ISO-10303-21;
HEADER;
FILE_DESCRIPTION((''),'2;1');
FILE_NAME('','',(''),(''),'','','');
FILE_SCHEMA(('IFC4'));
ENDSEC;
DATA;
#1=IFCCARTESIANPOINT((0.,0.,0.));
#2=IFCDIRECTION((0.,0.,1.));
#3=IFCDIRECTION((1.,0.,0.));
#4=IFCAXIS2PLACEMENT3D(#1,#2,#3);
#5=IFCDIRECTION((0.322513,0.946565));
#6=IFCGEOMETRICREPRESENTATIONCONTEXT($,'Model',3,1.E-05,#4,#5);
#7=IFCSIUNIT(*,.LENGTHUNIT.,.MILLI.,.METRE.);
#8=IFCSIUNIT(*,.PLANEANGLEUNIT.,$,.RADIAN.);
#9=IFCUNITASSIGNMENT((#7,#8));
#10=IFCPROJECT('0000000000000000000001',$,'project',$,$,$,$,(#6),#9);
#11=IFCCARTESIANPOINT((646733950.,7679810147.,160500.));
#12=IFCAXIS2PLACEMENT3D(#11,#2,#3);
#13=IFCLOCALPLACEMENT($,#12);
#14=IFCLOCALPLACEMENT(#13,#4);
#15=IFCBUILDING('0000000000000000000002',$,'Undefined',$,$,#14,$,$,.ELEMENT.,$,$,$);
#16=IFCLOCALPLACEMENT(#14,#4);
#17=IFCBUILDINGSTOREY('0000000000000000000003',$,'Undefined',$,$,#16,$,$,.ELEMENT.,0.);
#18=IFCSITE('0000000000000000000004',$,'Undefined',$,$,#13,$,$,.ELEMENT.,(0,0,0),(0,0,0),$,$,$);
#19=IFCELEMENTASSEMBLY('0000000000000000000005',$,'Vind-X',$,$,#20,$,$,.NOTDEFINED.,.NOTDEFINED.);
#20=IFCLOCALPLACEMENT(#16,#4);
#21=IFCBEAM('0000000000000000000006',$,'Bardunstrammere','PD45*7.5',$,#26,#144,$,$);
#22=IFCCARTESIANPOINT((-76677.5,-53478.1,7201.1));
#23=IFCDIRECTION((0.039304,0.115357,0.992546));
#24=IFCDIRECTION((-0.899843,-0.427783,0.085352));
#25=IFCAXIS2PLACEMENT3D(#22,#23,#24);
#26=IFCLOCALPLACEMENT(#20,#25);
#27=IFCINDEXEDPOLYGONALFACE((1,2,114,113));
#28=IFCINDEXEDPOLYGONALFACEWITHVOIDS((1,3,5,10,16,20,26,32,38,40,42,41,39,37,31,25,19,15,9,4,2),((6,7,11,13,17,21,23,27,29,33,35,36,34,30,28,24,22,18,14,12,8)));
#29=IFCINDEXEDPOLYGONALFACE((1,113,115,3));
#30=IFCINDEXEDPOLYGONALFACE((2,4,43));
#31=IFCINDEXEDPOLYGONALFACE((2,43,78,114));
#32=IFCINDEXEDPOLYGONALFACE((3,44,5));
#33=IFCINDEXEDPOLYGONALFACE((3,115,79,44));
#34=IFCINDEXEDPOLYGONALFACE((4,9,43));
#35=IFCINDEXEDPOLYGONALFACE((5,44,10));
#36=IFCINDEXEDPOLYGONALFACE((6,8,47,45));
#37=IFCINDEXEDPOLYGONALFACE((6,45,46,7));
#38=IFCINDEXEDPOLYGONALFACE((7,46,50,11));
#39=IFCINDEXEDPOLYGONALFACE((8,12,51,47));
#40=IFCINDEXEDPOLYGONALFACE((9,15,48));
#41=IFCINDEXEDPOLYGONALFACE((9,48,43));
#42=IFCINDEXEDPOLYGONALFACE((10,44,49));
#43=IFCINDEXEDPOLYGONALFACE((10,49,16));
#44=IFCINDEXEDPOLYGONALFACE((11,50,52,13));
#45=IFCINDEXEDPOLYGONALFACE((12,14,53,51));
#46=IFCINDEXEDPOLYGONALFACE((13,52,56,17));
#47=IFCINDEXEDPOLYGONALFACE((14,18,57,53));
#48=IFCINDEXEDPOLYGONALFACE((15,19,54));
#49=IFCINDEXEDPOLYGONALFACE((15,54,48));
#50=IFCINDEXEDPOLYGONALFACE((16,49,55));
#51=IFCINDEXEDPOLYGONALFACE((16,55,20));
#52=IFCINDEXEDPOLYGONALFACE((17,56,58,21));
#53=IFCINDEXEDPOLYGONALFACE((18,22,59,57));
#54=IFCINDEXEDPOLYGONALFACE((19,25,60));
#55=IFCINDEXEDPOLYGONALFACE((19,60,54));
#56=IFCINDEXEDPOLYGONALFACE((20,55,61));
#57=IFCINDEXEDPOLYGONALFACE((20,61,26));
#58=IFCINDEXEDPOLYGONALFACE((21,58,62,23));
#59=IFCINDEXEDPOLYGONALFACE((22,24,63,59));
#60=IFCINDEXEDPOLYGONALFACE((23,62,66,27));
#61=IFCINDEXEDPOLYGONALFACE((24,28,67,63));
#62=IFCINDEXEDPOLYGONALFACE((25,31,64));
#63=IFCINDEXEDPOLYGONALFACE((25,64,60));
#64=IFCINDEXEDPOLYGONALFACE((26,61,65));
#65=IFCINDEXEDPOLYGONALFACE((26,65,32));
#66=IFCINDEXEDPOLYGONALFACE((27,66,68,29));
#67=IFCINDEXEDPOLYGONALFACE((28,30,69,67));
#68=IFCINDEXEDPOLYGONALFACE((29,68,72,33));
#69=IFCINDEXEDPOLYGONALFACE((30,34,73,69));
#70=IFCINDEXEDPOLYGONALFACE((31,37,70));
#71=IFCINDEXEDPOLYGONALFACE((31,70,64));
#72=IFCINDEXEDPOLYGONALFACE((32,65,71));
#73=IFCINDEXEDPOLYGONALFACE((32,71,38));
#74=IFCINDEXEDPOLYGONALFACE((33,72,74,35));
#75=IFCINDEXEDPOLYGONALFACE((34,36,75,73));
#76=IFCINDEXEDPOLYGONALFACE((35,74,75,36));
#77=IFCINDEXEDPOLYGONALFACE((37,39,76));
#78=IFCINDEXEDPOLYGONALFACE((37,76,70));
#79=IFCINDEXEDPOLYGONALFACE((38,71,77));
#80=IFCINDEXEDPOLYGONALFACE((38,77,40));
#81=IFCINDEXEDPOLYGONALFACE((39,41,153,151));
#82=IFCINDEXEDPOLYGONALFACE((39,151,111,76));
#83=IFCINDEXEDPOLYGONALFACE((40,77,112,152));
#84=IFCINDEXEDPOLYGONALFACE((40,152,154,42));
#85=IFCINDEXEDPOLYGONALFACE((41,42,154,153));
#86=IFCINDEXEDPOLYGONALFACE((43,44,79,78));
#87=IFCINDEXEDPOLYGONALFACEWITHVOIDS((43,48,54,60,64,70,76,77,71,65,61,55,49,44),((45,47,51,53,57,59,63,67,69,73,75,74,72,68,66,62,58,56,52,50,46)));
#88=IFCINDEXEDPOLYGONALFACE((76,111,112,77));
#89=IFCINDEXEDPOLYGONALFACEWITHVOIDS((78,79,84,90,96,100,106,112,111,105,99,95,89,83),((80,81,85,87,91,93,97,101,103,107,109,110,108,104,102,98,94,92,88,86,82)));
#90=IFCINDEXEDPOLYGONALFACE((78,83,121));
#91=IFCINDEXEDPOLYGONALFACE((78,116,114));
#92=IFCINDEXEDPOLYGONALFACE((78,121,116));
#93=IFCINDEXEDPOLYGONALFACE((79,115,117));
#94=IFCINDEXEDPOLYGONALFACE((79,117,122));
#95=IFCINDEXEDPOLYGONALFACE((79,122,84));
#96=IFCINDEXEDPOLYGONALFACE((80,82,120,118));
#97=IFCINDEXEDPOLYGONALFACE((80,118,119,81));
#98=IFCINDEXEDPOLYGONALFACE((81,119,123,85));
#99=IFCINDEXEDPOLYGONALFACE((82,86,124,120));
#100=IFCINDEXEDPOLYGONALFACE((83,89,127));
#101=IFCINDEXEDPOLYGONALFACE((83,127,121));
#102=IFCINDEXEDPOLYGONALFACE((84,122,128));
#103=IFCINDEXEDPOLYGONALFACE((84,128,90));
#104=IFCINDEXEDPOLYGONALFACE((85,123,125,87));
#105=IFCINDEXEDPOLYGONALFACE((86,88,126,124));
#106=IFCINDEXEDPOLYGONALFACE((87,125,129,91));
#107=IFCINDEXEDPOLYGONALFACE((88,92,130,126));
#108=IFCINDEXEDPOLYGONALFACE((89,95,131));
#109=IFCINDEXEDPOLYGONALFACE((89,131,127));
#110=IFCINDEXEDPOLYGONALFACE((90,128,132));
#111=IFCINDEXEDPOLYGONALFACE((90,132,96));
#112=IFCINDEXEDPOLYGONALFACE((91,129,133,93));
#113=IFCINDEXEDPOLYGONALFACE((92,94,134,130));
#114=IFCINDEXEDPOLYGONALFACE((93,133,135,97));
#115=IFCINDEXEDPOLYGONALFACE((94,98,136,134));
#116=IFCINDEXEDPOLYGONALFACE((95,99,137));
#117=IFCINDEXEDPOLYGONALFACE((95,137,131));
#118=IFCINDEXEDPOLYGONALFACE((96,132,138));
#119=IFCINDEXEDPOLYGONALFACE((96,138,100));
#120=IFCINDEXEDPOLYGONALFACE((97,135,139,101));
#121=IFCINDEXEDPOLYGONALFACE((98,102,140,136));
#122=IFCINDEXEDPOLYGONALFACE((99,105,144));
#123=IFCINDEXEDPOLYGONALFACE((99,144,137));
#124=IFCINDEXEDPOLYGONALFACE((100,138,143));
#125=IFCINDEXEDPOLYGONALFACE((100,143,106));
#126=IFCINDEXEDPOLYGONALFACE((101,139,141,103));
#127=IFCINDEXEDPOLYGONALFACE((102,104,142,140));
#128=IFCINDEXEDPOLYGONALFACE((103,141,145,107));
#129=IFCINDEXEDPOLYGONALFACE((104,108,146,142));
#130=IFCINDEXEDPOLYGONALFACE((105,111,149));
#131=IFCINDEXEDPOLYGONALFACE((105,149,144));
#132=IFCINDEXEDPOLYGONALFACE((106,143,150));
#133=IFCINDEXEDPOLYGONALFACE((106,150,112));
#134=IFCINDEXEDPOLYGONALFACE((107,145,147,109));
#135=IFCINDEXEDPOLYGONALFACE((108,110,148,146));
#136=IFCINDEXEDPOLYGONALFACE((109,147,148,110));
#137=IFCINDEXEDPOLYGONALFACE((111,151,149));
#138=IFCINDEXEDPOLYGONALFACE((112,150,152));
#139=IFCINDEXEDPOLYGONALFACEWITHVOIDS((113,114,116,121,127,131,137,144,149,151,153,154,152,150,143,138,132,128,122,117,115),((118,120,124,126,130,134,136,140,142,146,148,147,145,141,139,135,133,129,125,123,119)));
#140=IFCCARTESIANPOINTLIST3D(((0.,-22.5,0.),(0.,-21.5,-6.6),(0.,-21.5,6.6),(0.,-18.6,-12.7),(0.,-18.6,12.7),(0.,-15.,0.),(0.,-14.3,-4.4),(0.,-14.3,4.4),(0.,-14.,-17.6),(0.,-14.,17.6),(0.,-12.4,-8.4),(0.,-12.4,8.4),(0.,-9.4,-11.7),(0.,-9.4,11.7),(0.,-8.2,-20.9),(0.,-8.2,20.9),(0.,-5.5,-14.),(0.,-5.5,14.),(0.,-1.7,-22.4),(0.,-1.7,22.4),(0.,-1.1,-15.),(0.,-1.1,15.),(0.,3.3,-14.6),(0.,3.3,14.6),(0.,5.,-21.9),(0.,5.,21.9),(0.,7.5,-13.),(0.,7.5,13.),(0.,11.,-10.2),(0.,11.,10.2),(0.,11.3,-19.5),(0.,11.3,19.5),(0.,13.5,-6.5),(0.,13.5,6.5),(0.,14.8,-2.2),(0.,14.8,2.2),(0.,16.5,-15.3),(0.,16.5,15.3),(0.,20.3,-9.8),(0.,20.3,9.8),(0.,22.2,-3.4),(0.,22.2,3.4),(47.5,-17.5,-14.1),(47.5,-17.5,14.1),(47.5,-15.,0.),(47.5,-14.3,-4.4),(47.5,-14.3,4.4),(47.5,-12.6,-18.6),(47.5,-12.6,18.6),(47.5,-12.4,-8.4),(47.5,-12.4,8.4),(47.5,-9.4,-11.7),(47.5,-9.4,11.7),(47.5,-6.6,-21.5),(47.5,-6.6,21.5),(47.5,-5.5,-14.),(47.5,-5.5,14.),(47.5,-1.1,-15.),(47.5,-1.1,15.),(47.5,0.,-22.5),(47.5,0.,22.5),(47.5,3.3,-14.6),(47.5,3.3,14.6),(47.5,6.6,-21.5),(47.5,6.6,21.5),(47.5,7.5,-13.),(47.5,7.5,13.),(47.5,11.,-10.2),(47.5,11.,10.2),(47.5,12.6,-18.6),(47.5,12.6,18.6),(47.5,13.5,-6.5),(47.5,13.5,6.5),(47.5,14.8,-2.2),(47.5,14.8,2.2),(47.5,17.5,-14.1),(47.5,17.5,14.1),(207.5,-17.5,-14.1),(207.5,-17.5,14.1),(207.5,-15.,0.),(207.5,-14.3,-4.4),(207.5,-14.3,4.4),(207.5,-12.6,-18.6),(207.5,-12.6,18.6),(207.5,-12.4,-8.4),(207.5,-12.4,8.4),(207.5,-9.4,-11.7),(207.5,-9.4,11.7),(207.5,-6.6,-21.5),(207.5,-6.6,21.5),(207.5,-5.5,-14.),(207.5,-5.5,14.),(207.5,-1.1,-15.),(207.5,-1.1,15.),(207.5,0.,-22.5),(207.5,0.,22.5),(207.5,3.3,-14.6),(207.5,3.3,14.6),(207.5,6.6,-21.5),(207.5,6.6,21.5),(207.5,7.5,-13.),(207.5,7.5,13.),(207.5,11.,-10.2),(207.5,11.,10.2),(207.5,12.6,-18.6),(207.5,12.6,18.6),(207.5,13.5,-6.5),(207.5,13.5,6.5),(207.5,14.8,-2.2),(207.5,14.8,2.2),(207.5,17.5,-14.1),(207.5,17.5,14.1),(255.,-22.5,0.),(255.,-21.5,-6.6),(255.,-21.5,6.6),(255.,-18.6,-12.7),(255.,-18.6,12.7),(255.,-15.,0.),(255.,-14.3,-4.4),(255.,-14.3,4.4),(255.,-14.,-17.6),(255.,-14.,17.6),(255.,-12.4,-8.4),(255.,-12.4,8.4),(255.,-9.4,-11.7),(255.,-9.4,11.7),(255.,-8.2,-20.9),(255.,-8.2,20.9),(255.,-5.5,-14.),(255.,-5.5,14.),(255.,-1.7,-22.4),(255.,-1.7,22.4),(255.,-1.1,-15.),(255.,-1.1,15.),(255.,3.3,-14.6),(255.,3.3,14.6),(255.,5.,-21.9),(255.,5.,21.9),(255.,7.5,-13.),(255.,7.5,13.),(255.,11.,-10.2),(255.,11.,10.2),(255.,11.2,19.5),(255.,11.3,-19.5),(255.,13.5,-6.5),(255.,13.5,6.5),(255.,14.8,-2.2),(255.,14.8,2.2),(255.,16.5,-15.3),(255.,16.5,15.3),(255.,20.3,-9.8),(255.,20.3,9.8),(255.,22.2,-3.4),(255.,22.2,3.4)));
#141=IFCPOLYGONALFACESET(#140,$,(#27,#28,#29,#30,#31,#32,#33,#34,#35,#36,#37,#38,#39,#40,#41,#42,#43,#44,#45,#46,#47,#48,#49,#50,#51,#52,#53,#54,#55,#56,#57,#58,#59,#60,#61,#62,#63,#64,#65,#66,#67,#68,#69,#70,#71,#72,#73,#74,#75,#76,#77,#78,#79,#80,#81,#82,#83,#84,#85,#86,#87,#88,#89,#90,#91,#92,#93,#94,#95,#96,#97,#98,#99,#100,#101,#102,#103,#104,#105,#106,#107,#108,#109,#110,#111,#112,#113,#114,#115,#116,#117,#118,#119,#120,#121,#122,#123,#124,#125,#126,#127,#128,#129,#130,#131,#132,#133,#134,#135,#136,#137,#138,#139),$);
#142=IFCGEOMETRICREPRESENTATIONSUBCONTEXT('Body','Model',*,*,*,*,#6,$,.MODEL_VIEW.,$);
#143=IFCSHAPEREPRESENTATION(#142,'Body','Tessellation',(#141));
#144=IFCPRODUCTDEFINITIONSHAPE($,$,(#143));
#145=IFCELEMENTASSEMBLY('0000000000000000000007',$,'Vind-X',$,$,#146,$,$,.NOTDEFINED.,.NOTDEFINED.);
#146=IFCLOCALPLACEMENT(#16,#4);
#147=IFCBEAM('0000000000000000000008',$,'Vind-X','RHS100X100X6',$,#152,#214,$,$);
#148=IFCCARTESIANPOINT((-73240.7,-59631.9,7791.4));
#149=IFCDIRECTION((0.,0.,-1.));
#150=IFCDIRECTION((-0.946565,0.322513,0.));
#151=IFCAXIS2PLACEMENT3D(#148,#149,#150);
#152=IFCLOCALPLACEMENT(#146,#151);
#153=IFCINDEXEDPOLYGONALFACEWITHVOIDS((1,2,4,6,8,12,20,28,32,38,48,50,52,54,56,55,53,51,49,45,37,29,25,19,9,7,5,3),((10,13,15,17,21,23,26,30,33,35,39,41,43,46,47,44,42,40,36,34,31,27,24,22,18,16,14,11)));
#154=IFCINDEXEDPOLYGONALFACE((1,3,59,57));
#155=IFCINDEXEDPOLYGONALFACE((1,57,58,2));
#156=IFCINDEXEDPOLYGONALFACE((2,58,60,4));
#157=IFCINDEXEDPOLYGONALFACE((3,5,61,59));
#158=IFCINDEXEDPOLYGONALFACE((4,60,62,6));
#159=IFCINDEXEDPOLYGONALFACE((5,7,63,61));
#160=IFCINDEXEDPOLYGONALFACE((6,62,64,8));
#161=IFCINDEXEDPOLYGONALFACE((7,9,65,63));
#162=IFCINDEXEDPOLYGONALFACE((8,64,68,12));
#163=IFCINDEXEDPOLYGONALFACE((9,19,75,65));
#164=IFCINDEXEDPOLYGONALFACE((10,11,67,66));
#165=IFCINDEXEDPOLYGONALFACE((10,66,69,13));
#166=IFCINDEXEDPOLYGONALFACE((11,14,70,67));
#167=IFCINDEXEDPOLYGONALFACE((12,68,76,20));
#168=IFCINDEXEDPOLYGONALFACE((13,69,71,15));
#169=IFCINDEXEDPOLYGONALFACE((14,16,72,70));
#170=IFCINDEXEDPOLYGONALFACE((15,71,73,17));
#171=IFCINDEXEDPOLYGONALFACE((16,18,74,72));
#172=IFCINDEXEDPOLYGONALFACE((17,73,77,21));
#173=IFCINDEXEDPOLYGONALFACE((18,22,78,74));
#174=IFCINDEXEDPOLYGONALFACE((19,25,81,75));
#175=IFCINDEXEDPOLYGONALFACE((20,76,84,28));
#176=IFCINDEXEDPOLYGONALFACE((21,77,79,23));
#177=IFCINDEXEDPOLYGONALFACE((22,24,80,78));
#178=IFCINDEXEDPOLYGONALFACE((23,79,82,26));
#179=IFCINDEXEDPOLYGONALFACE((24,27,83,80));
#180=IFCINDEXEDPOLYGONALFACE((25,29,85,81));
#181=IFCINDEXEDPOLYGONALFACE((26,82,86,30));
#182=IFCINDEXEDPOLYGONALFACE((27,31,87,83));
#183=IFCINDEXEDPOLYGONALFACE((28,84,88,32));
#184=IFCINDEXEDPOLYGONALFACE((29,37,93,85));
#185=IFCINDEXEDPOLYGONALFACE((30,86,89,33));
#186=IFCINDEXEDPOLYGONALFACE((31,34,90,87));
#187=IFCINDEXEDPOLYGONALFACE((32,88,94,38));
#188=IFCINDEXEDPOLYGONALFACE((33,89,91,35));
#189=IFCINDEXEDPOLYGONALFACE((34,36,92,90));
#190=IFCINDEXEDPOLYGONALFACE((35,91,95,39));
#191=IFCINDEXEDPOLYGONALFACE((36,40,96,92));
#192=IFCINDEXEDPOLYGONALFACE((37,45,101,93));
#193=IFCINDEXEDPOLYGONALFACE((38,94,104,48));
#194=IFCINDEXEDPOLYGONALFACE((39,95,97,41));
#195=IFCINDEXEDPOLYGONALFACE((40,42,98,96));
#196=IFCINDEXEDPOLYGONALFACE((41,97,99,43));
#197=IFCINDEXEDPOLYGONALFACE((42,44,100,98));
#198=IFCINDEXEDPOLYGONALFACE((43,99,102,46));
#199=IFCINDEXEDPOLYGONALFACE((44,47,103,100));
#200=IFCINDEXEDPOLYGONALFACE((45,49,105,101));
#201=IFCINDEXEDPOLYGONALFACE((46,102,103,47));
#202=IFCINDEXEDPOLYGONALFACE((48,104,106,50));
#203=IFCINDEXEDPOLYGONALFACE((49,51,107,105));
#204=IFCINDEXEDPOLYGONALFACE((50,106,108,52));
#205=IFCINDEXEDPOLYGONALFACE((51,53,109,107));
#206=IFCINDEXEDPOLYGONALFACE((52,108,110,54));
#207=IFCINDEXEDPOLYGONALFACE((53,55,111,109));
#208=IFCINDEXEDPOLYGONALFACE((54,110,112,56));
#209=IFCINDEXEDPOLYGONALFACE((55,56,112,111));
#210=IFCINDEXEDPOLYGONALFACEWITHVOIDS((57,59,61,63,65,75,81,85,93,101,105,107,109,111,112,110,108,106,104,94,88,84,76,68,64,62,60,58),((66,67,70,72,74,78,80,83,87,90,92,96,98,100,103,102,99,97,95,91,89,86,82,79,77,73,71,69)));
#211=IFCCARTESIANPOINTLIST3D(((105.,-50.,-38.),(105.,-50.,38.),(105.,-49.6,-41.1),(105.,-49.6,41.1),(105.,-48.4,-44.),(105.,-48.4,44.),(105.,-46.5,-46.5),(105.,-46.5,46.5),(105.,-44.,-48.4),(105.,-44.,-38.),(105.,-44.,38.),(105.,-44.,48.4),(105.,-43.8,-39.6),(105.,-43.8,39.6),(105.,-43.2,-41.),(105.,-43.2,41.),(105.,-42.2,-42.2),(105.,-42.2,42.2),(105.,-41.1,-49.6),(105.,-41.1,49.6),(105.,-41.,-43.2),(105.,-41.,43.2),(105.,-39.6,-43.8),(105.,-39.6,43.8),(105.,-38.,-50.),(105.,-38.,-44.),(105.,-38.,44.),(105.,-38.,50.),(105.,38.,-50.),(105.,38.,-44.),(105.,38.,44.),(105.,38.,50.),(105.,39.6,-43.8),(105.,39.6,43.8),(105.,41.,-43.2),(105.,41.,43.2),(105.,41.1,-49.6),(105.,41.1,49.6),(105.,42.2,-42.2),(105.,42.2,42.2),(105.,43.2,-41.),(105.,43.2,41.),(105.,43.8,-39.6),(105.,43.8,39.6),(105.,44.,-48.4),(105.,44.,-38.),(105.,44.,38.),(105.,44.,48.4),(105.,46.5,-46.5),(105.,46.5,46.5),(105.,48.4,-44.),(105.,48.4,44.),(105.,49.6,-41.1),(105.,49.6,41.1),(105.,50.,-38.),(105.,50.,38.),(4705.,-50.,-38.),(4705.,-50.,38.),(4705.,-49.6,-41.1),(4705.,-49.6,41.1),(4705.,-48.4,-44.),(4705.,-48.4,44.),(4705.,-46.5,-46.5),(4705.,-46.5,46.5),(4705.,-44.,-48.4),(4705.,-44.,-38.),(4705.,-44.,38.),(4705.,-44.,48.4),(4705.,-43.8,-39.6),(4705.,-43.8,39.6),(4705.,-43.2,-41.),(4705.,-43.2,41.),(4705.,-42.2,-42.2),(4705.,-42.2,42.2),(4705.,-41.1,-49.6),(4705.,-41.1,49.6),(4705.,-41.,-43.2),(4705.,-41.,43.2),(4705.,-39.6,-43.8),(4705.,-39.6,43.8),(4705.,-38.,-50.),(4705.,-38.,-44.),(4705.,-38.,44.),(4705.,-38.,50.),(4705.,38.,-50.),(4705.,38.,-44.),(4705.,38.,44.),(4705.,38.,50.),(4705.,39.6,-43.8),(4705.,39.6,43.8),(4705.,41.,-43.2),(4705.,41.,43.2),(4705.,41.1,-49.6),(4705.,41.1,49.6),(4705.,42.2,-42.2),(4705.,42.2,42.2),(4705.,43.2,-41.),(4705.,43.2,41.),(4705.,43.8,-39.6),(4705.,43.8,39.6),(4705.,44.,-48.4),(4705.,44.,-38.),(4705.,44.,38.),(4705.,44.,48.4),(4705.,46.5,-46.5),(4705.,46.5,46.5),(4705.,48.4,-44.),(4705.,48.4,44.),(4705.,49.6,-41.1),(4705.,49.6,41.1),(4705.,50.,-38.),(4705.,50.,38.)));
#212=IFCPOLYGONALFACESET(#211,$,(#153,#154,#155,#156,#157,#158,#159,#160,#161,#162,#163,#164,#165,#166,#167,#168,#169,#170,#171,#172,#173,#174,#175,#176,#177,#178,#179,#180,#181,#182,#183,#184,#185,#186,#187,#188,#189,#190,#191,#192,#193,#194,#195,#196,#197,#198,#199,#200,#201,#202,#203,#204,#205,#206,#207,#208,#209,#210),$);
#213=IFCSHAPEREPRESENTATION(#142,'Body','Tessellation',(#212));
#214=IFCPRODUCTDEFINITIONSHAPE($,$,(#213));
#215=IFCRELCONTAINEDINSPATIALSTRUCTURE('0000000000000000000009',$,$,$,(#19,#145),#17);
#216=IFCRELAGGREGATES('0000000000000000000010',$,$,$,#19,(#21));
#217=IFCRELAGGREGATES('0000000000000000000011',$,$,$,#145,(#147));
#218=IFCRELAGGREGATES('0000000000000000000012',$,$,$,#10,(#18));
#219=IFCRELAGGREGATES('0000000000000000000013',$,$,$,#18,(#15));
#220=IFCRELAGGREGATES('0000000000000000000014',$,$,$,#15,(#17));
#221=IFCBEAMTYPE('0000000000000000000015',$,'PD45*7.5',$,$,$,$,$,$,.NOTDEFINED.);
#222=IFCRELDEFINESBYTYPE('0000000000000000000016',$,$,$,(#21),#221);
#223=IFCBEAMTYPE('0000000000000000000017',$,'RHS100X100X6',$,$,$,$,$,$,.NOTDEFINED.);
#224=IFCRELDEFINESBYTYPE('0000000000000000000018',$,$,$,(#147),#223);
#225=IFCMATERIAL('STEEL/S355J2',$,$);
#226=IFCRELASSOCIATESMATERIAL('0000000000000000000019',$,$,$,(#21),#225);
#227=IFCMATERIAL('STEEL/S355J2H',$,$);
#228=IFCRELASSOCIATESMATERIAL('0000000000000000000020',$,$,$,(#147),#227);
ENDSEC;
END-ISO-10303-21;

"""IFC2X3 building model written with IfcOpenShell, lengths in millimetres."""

from ifc_helpers import new_model, si_unit, direction, frame, origin_with_axes, origin_2d_with_axis, place, context, subcontext, project, spatial, rectangle, hollow_rectangle, hollow_circle, extrude, boolean, clip, halfspace, material, type_object, element, aggregate, save


model = new_model("IFC2X3")

# Units and contexts
model_context = context("Model", 3, precision=1e-05, world=origin_with_axes(), true_north=direction((0.322513, 0.946565)))
body_context = subcontext(model_context, "Body", "Model", "MODEL_VIEW")
ifc_project = project(units=[si_unit("LENGTHUNIT", "METRE", prefix="MILLI"), si_unit("PLANEANGLEUNIT", "RADIAN")], contexts=[model_context])

# Site, building, storey
site_placement = place(None, frame((646733950.0, 7679810147.0, 160500.0), z_axis=(0.0, 0.0, 1.0), x_axis=(1.0, 0.0, 0.0)))
site = spatial("IfcSite", under=ifc_project, at=site_placement, Name="Undefined", CompositionType="ELEMENT", RefLatitude=(0, 0, 0), RefLongitude=(0, 0, 0))
building_placement = place(site_placement, origin_with_axes())
building = spatial("IfcBuilding", under=site, at=building_placement, Name="Undefined", CompositionType="ELEMENT")
storey_placement = place(building_placement, origin_with_axes())
storey = spatial("IfcBuildingStorey", under=building, at=storey_placement, Name="Undefined", CompositionType="ELEMENT", Elevation=0.0)

# Element assembly, beam
assembly_1_placement = place(storey_placement, origin_with_axes())
assembly_1 = element("IfcElementAssembly", 1, at=assembly_1_placement, inside=storey, Name="Vind-X", AssemblyPlace="NOTDEFINED", PredefinedType="NOTDEFINED")
ifc_material_1 = material(Name="STEEL/S355J2")
beam_type_1 = type_object("IfcBeamType", Name="PD45*7.5", PredefinedType="NOTDEFINED")
beam_1_placement = place(assembly_1_placement, frame((-76677.5, -53478.1, 7201.1), z_axis=(0.039304, 0.115357, 0.992546), x_axis=(-0.899843, -0.427783, 0.085352)))
beam_1 = element("IfcBeam", 2, at=beam_1_placement, type_object=beam_type_1, material=ifc_material_1, Name="Bardunstrammere", Description="PD45*7.5", context=body_context, shape_type="CSG", body=[
    boolean("DIFFERENCE", extrude(hollow_circle(Radius=22.5, WallThickness=7.5, at=origin_2d_with_axis()), frame((255.0, 0.0, 0.0), z_axis=(-1.0, 0.0, 0.0), x_axis=(0.0, -1.0, 0.0)), (0.0, 0.0, 1.0), 255.0), extrude(rectangle(XDim=35.0, YDim=90.0, at=origin_2d_with_axis()), frame((207.5, 0.0, 0.0), z_axis=(-1.0, 0.0, 0.0), x_axis=(0.0, -1.0, 0.0)), (0.0, 0.0, 1.0), 160.0)),
])
aggregate(assembly_1, [beam_1])

# Element assembly, beam
assembly_2_placement = place(storey_placement, origin_with_axes())
assembly_2 = element("IfcElementAssembly", 3, at=assembly_2_placement, inside=storey, Name="Vind-X", AssemblyPlace="NOTDEFINED", PredefinedType="NOTDEFINED")
ifc_material_2 = material(Name="STEEL/S355J2H")
beam_type_2 = type_object("IfcBeamType", Name="RHS100X100X6", PredefinedType="NOTDEFINED")
beam_2_placement = place(assembly_2_placement, frame((-73240.7, -59631.9, 7791.4), z_axis=(0.0, 0.0, -1.0), x_axis=(-0.946565, 0.322513, 0.0)))
beam_2 = element("IfcBeam", 4, at=beam_2_placement, type_object=beam_type_2, material=ifc_material_2, Name="Vind-X", Description="RHS100X100X6", context=body_context, shape_type="Clipping", body=[
    clip(clip(extrude(hollow_rectangle(XDim=100.0, YDim=100.0, WallThickness=6.0, InnerFilletRadius=6.0, OuterFilletRadius=12.0, at=origin_2d_with_axis()), frame((4810.0, 0.0, 0.0), z_axis=(-1.0, 0.0, 0.0), x_axis=(0.0, -1.0, 0.0)), (0.0, 0.0, 1.0), 4810.0), halfspace(frame((4705.0, 0.0, 0.0), z_axis=(-1.0, 0.0, 0.0), x_axis=(0.0, 1.0, 0.0)), True)), halfspace(frame((105.0, 0.0, 0.0), z_axis=(1.0, 0.0, 0.0), x_axis=(0.0, -1.0, 0.0)), True)),
])

aggregate(assembly_2, [beam_2])

save(model, "model.ifc")
